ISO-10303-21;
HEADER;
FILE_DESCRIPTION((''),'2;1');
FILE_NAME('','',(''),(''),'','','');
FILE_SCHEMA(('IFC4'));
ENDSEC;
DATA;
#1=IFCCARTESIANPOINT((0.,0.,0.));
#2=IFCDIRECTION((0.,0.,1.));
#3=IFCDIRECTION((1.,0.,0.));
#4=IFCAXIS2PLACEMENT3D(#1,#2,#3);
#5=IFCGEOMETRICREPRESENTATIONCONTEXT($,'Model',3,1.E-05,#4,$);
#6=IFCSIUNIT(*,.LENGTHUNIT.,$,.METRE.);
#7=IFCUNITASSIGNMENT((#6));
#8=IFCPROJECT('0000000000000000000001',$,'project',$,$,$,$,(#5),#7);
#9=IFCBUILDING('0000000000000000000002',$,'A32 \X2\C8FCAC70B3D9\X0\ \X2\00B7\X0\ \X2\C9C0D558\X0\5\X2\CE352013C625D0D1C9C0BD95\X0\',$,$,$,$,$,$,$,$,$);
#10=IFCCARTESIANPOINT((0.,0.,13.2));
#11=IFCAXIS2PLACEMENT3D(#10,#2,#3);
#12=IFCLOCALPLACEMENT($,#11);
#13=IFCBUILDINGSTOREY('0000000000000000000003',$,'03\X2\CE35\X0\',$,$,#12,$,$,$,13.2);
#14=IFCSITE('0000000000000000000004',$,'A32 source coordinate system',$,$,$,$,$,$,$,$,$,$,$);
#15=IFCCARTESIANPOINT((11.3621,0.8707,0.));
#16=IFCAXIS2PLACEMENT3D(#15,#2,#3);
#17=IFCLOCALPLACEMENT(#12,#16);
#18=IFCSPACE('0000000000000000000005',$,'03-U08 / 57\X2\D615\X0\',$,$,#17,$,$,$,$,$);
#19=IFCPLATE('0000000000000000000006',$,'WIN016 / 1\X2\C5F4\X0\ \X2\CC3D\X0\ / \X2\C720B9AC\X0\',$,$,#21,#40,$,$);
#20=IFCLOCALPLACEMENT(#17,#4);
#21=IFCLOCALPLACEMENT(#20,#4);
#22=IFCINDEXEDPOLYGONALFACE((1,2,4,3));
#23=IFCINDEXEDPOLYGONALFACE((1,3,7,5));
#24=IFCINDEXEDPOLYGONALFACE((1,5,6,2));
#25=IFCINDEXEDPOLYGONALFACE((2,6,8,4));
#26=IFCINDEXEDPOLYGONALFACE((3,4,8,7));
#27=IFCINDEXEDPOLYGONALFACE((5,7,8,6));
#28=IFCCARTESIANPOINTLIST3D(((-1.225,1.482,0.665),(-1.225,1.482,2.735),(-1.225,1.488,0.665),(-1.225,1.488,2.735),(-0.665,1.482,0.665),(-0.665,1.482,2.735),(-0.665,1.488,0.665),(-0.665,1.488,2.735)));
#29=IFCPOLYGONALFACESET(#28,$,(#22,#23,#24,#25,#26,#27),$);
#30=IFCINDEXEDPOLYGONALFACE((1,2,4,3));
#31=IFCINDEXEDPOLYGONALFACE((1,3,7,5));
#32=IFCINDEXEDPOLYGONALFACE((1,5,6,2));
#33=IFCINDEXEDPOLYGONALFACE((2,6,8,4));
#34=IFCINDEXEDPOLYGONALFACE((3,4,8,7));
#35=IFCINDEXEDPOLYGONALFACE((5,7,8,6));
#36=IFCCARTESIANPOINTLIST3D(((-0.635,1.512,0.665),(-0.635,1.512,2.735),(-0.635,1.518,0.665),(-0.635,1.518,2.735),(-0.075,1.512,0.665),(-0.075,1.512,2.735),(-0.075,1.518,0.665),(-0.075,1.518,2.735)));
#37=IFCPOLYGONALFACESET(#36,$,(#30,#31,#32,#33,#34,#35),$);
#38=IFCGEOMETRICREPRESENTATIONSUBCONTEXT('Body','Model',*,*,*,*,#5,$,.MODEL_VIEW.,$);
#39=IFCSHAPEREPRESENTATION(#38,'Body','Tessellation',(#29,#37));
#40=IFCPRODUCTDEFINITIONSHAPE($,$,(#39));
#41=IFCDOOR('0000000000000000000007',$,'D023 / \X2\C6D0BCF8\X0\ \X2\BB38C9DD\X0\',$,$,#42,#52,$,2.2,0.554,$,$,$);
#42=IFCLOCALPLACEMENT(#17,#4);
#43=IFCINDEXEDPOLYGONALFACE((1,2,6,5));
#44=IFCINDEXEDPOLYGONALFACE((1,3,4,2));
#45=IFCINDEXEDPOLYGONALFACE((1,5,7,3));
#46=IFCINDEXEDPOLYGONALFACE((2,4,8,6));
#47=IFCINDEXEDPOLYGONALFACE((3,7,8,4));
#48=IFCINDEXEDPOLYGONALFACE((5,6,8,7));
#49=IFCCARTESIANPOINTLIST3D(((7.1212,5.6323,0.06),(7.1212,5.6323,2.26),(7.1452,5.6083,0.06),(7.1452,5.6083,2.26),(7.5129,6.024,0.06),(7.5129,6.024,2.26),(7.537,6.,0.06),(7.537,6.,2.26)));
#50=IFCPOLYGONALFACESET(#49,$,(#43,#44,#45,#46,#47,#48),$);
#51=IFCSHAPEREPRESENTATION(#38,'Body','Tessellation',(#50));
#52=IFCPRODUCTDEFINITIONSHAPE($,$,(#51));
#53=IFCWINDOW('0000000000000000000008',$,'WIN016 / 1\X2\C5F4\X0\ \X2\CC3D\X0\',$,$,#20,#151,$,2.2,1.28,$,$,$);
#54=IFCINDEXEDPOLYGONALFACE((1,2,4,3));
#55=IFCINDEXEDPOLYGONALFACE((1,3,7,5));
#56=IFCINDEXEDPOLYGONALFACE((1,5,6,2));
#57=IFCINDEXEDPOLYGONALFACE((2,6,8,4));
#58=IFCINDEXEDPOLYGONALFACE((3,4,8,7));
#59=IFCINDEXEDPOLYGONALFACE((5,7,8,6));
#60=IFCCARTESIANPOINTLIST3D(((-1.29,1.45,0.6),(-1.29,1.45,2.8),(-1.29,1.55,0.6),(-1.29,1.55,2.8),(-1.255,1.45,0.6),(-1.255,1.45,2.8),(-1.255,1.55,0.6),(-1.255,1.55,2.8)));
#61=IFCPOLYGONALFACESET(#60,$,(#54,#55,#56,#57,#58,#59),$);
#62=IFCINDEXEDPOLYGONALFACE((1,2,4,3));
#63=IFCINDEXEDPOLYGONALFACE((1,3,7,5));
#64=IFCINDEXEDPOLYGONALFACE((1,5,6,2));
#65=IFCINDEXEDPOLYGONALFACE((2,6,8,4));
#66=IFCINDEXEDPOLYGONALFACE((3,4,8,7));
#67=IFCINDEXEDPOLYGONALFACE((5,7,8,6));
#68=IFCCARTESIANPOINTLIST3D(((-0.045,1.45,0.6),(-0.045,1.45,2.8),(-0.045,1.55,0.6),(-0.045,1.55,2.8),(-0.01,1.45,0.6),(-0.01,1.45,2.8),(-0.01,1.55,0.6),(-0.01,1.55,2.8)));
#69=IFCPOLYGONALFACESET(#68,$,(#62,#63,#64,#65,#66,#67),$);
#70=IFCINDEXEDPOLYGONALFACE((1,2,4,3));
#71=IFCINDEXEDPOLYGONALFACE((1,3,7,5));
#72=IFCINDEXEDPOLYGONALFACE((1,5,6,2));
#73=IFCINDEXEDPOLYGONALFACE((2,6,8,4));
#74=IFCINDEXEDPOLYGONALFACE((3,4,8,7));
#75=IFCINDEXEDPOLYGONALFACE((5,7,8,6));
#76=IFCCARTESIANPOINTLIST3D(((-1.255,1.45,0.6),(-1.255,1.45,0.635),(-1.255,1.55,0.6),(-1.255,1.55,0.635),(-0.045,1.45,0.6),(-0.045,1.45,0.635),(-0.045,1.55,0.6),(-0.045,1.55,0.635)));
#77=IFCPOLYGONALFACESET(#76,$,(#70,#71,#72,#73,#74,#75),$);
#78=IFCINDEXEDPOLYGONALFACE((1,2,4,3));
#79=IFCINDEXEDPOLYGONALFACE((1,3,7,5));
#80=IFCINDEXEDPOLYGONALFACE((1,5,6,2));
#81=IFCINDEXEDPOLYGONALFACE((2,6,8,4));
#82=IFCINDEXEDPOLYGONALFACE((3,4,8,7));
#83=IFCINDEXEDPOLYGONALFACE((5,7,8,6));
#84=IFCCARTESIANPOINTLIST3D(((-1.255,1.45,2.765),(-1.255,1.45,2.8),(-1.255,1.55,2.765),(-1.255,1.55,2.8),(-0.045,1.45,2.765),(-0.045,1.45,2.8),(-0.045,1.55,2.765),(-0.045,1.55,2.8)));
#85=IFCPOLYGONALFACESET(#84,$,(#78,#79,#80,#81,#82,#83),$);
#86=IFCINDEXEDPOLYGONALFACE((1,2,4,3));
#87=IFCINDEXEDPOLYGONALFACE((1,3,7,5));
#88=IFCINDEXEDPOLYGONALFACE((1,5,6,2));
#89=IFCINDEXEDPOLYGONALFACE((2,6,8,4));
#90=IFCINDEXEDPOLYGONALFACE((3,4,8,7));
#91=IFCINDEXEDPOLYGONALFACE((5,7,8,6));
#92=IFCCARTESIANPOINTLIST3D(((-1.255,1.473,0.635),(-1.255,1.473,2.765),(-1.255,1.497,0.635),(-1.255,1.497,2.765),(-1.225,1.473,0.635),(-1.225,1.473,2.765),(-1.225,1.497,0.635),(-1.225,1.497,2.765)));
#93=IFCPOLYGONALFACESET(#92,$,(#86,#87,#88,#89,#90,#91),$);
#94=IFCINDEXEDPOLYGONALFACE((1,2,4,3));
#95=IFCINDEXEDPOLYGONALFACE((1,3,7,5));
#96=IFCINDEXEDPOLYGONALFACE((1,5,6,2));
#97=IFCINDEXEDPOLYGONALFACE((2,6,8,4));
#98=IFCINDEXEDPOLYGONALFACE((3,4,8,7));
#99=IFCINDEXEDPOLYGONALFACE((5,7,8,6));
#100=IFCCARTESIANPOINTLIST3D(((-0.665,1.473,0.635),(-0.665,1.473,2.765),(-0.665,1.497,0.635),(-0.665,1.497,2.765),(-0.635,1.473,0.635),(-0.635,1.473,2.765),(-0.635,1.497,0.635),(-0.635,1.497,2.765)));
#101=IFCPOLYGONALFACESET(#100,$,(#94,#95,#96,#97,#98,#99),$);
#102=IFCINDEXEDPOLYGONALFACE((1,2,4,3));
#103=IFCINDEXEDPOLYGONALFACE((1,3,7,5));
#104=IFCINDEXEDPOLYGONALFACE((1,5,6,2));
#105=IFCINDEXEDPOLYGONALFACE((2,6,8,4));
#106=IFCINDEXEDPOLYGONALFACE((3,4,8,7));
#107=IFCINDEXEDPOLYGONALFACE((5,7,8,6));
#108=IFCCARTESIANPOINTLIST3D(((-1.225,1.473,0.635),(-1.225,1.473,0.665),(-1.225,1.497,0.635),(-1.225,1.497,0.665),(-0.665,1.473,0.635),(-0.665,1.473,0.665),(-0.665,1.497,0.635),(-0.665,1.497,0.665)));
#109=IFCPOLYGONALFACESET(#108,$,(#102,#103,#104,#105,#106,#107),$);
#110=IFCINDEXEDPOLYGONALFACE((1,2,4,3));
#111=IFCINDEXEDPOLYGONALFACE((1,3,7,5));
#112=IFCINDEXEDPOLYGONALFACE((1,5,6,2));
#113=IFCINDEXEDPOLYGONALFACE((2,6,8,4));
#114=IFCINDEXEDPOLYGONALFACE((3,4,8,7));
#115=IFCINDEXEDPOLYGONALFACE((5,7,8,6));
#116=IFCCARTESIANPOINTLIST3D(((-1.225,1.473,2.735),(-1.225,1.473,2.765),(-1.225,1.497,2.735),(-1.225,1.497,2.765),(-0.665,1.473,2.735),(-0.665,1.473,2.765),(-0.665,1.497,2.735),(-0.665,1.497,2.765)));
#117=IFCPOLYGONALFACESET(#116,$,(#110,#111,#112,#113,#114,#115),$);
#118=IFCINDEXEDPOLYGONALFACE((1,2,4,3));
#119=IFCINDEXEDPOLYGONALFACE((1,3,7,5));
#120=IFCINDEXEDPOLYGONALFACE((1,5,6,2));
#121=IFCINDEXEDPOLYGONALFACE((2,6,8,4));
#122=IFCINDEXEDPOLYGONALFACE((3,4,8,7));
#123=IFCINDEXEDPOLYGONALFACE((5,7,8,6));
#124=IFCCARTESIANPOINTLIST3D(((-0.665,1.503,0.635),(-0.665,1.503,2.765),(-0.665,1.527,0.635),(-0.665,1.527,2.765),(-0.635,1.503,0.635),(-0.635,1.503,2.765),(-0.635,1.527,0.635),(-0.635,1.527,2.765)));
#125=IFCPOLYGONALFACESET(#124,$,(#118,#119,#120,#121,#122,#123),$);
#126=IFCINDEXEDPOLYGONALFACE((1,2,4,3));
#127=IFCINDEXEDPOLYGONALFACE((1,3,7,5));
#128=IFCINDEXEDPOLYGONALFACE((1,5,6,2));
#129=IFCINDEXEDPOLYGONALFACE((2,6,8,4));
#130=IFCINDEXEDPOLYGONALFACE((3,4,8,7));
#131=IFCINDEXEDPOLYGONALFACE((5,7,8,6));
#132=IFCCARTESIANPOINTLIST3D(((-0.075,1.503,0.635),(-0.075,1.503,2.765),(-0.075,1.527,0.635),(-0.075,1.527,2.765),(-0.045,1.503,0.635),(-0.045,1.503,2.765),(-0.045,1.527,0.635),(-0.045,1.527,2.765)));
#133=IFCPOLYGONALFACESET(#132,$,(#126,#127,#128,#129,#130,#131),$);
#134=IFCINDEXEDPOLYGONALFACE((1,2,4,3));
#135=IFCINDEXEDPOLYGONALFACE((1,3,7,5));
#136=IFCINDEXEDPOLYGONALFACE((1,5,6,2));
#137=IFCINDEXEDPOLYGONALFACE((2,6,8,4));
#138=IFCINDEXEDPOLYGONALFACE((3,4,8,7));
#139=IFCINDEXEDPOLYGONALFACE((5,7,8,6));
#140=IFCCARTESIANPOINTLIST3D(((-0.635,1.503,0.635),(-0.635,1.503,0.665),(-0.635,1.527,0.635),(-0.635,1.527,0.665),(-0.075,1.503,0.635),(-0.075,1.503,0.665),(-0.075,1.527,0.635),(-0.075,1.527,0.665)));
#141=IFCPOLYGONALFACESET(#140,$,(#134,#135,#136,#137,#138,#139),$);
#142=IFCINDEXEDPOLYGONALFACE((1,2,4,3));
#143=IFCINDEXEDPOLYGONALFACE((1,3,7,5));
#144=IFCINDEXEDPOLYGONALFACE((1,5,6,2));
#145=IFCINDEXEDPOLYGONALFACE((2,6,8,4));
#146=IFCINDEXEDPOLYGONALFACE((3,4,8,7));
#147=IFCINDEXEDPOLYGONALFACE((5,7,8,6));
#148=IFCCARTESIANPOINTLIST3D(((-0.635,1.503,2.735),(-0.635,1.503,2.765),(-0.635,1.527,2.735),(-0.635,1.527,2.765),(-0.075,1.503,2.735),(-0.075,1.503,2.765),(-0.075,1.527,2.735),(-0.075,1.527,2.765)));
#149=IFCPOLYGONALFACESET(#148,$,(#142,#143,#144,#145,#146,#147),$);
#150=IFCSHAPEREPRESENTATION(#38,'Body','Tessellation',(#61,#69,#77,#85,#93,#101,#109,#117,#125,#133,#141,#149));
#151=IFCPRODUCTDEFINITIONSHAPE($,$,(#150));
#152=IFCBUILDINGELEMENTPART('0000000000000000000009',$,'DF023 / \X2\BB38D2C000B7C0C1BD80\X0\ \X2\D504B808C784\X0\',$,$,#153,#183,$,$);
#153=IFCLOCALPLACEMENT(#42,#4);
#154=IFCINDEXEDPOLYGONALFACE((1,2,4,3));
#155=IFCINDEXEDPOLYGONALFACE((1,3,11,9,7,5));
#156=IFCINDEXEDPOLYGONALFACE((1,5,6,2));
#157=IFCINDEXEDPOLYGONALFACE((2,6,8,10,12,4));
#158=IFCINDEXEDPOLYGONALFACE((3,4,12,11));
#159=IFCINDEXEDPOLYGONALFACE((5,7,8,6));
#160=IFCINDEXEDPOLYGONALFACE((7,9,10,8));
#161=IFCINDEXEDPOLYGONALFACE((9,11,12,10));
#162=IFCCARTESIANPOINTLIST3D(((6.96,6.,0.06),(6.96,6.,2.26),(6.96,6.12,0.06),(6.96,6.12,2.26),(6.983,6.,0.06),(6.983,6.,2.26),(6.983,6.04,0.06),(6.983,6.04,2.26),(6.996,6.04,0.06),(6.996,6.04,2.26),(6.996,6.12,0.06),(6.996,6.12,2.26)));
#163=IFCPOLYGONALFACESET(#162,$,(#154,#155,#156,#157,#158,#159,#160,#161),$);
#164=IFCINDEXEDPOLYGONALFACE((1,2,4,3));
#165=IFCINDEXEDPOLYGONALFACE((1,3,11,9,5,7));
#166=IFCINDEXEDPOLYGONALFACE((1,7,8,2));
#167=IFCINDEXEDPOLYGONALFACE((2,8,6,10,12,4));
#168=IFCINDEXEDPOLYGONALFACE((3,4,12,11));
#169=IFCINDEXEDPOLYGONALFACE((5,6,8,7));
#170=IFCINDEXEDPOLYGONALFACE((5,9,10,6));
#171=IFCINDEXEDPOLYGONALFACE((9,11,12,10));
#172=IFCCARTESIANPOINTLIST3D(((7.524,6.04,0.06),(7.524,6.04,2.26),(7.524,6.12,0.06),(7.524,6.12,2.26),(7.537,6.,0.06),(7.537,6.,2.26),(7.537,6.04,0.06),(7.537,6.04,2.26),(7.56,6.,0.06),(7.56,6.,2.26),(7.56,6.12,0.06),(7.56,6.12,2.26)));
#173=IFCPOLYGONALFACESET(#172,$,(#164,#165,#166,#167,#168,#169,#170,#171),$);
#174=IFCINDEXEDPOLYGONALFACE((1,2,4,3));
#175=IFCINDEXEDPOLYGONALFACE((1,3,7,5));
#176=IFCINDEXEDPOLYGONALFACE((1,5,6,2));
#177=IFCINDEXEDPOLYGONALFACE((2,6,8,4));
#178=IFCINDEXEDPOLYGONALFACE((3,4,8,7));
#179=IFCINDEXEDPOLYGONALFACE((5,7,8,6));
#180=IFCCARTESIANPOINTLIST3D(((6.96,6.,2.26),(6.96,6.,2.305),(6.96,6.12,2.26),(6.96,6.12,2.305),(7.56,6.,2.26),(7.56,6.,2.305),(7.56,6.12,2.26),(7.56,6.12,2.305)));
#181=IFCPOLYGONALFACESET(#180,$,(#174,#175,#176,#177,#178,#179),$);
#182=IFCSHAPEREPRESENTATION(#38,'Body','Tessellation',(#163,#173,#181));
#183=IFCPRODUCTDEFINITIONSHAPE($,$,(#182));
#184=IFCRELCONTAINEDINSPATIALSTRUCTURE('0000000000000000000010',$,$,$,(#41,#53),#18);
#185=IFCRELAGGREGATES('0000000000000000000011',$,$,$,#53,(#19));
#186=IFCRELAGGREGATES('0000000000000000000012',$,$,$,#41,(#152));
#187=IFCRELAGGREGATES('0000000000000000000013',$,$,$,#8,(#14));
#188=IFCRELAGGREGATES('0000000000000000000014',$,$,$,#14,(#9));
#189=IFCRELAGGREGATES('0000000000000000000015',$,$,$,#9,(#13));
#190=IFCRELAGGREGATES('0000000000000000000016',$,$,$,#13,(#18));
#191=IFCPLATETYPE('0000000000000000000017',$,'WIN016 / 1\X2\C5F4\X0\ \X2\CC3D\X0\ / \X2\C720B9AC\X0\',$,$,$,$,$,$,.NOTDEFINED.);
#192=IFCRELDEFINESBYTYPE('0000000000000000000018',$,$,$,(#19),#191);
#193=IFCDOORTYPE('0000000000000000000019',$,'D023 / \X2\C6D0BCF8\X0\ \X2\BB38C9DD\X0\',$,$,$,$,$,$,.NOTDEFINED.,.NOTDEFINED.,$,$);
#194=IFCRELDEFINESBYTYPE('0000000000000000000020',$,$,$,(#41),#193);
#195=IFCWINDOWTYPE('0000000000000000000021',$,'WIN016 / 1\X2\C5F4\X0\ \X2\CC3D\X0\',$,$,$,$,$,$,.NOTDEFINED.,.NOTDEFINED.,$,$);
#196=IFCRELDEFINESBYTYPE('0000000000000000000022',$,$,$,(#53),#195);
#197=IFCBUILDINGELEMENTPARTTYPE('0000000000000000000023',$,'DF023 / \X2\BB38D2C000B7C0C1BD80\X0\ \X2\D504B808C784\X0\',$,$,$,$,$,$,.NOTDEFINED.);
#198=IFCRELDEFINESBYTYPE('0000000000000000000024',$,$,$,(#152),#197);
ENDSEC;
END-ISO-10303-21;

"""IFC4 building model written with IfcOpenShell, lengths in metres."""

from ifc_helpers import new_model, si_unit, frame, origin, origin_with_axes, place, context, subcontext, project, spatial, polyline, outline, extrude, source, transform, mapped, type_object, type_shapes, element, aggregate, save


model = new_model("IFC4")

# Units and contexts
model_context = context("Model", 3, precision=1e-05, world=origin_with_axes())
body_context = subcontext(model_context, "Body", "Model", "MODEL_VIEW")
ifc_project = project(units=[si_unit("LENGTHUNIT", "METRE")], contexts=[model_context])

# Plate
storey_placement = place(None, frame((0.0, 0.0, 13.2), z_axis=(0.0, 0.0, 1.0), x_axis=(1.0, 0.0, 0.0)))
space_1_placement = place(storey_placement, frame((11.3621, 0.8707, 0.0), z_axis=(0.0, 0.0, 1.0), x_axis=(1.0, 0.0, 0.0)))
plate_type_1 = type_object("IfcPlateType", Name="WIN016 / 1열 창 / 유리", PredefinedType="NOTDEFINED")
shared_shape_1 = source(origin(), body_context, "Body", "SweptSolid", [
    extrude(outline(polyline([(-1.225, 1.482), (-1.225, 1.488), (-0.665, 1.488), (-0.665, 1.482), (-1.225, 1.482)])), frame((0.0, 0.0, 0.665)), (0.0, 0.0, 1.0), 2.07),
    extrude(outline(polyline([(-0.635, 1.512), (-0.635, 1.518), (-0.075, 1.518), (-0.075, 1.512), (-0.635, 1.512)])), frame((0.0, 0.0, 0.665)), (0.0, 0.0, 1.0), 2.07),
])
type_shapes(plate_type_1, [shared_shape_1])
window_1_placement = place(space_1_placement, origin_with_axes())
plate_1_placement = place(window_1_placement, origin_with_axes())
plate_1 = element("IfcPlate", 1, at=plate_1_placement, type_object=plate_type_1, Name="WIN016 / 1열 창 / 유리", context=body_context, shape_type="MappedRepresentation", body=[
    mapped(shared_shape_1, transform((0.0, 0.0, 0.0), scale=1.0)),
])

# Site, building, storey, space
site = spatial("IfcSite", under=ifc_project, Name="A32 source coordinate system")
building = spatial("IfcBuilding", under=site, Name="A32 주거동 · 지하5층–옥탑지붕")
storey = spatial("IfcBuildingStorey", under=building, at=storey_placement, Name="03층", Elevation=13.2)
space_1 = spatial("IfcSpace", under=storey, at=space_1_placement, Name="03-U08 / 57형")

# Door
door_type_1 = type_object("IfcDoorType", Name="D023 / 원본 문짝", OperationType="NOTDEFINED", PredefinedType="NOTDEFINED")
shared_shape_2 = source(origin(), body_context, "Body", "SweptSolid", [
    extrude(outline(polyline([(7.537, 6.0), (7.1452, 5.6083), (7.1212, 5.6323), (7.5129, 6.024), (7.537, 6.0)])), frame((0.0, 0.0, 0.06)), (0.0, 0.0, 1.0), 2.2),
])
type_shapes(door_type_1, [shared_shape_2])
door_1_placement = place(space_1_placement, origin_with_axes())
door_1 = element("IfcDoor", 2, at=door_1_placement, inside=space_1, type_object=door_type_1, Name="D023 / 원본 문짝", OverallHeight=2.2, OverallWidth=0.554, context=body_context, shape_type="MappedRepresentation", body=[
    mapped(shared_shape_2, transform((0.0, 0.0, 0.0), scale=1.0)),
])

# Window
window_type_1 = type_object("IfcWindowType", Name="WIN016 / 1열 창", PartitioningType="NOTDEFINED", PredefinedType="NOTDEFINED")
shared_shape_3 = source(origin(), body_context, "Body", "SweptSolid", [
    extrude(outline(polyline([(-1.29, 1.45), (-1.29, 1.55), (-1.255, 1.55), (-1.255, 1.45), (-1.29, 1.45)])), frame((0.0, 0.0, 0.6)), (0.0, 0.0, 1.0), 2.2),
    extrude(outline(polyline([(-0.045, 1.45), (-0.045, 1.55), (-0.01, 1.55), (-0.01, 1.45), (-0.045, 1.45)])), frame((0.0, 0.0, 0.6)), (0.0, 0.0, 1.0), 2.2),
    extrude(outline(polyline([(-1.255, 1.45), (-1.255, 1.55), (-0.045, 1.55), (-0.045, 1.45), (-1.255, 1.45)])), frame((0.0, 0.0, 0.6)), (0.0, 0.0, 1.0), 0.035),
    extrude(outline(polyline([(-1.255, 1.45), (-1.255, 1.55), (-0.045, 1.55), (-0.045, 1.45), (-1.255, 1.45)])), frame((0.0, 0.0, 2.765)), (0.0, 0.0, 1.0), 0.035),
    extrude(outline(polyline([(-1.255, 1.473), (-1.255, 1.497), (-1.225, 1.497), (-1.225, 1.473), (-1.255, 1.473)])), frame((0.0, 0.0, 0.635)), (0.0, 0.0, 1.0), 2.13),
    extrude(outline(polyline([(-0.665, 1.473), (-0.665, 1.497), (-0.635, 1.497), (-0.635, 1.473), (-0.665, 1.473)])), frame((0.0, 0.0, 0.635)), (0.0, 0.0, 1.0), 2.13),
    extrude(outline(polyline([(-1.225, 1.473), (-1.225, 1.497), (-0.665, 1.497), (-0.665, 1.473), (-1.225, 1.473)])), frame((0.0, 0.0, 0.635)), (0.0, 0.0, 1.0), 0.03),
    extrude(outline(polyline([(-1.225, 1.473), (-1.225, 1.497), (-0.665, 1.497), (-0.665, 1.473), (-1.225, 1.473)])), frame((0.0, 0.0, 2.735)), (0.0, 0.0, 1.0), 0.03),
    extrude(outline(polyline([(-0.665, 1.503), (-0.665, 1.527), (-0.635, 1.527), (-0.635, 1.503), (-0.665, 1.503)])), frame((0.0, 0.0, 0.635)), (0.0, 0.0, 1.0), 2.13),
    extrude(outline(polyline([(-0.075, 1.503), (-0.075, 1.527), (-0.045, 1.527), (-0.045, 1.503), (-0.075, 1.503)])), frame((0.0, 0.0, 0.635)), (0.0, 0.0, 1.0), 2.13),
    extrude(outline(polyline([(-0.635, 1.503), (-0.635, 1.527), (-0.075, 1.527), (-0.075, 1.503), (-0.635, 1.503)])), frame((0.0, 0.0, 0.635)), (0.0, 0.0, 1.0), 0.03),
    extrude(outline(polyline([(-0.635, 1.503), (-0.635, 1.527), (-0.075, 1.527), (-0.075, 1.503), (-0.635, 1.503)])), frame((0.0, 0.0, 2.735)), (0.0, 0.0, 1.0), 0.03),
])
type_shapes(window_type_1, [shared_shape_3])
window_1 = element("IfcWindow", 3, at=window_1_placement, inside=space_1, type_object=window_type_1, Name="WIN016 / 1열 창", OverallHeight=2.2, OverallWidth=1.28, context=body_context, shape_type="MappedRepresentation", body=[
    mapped(shared_shape_3, transform((0.0, 0.0, 0.0), scale=1.0)),
])
aggregate(window_1, [plate_1])

# Building element part
building_element_part_type_1 = type_object("IfcBuildingElementPartType", Name="DF023 / 문틀·상부 프레임", PredefinedType="NOTDEFINED")
shared_shape_4 = source(origin(), body_context, "Body", "SweptSolid", [
    extrude(outline(polyline([(6.996, 6.12), (6.996, 6.04), (6.983, 6.04), (6.983, 6.0), (6.96, 6.0), (6.96, 6.12), (6.996, 6.12)])), frame((0.0, 0.0, 0.06)), (0.0, 0.0, 1.0), 2.2),
    extrude(outline(polyline([(7.56, 6.0), (7.537, 6.0), (7.537, 6.04), (7.524, 6.04), (7.524, 6.12), (7.56, 6.12), (7.56, 6.0)])), frame((0.0, 0.0, 0.06)), (0.0, 0.0, 1.0), 2.2),
    extrude(outline(polyline([(6.96, 6.0), (6.96, 6.12), (7.56, 6.12), (7.56, 6.0), (6.96, 6.0)])), frame((0.0, 0.0, 2.26)), (0.0, 0.0, 1.0), 0.045),
])
type_shapes(building_element_part_type_1, [shared_shape_4])
building_element_part_1_placement = place(door_1_placement, origin_with_axes())
building_element_part_1 = element("IfcBuildingElementPart", 4, at=building_element_part_1_placement, type_object=building_element_part_type_1, Name="DF023 / 문틀·상부 프레임", context=body_context, shape_type="MappedRepresentation", body=[
    mapped(shared_shape_4, transform((0.0, 0.0, 0.0), scale=1.0)),
])
aggregate(door_1, [building_element_part_1])

save(model, "model.ifc")
